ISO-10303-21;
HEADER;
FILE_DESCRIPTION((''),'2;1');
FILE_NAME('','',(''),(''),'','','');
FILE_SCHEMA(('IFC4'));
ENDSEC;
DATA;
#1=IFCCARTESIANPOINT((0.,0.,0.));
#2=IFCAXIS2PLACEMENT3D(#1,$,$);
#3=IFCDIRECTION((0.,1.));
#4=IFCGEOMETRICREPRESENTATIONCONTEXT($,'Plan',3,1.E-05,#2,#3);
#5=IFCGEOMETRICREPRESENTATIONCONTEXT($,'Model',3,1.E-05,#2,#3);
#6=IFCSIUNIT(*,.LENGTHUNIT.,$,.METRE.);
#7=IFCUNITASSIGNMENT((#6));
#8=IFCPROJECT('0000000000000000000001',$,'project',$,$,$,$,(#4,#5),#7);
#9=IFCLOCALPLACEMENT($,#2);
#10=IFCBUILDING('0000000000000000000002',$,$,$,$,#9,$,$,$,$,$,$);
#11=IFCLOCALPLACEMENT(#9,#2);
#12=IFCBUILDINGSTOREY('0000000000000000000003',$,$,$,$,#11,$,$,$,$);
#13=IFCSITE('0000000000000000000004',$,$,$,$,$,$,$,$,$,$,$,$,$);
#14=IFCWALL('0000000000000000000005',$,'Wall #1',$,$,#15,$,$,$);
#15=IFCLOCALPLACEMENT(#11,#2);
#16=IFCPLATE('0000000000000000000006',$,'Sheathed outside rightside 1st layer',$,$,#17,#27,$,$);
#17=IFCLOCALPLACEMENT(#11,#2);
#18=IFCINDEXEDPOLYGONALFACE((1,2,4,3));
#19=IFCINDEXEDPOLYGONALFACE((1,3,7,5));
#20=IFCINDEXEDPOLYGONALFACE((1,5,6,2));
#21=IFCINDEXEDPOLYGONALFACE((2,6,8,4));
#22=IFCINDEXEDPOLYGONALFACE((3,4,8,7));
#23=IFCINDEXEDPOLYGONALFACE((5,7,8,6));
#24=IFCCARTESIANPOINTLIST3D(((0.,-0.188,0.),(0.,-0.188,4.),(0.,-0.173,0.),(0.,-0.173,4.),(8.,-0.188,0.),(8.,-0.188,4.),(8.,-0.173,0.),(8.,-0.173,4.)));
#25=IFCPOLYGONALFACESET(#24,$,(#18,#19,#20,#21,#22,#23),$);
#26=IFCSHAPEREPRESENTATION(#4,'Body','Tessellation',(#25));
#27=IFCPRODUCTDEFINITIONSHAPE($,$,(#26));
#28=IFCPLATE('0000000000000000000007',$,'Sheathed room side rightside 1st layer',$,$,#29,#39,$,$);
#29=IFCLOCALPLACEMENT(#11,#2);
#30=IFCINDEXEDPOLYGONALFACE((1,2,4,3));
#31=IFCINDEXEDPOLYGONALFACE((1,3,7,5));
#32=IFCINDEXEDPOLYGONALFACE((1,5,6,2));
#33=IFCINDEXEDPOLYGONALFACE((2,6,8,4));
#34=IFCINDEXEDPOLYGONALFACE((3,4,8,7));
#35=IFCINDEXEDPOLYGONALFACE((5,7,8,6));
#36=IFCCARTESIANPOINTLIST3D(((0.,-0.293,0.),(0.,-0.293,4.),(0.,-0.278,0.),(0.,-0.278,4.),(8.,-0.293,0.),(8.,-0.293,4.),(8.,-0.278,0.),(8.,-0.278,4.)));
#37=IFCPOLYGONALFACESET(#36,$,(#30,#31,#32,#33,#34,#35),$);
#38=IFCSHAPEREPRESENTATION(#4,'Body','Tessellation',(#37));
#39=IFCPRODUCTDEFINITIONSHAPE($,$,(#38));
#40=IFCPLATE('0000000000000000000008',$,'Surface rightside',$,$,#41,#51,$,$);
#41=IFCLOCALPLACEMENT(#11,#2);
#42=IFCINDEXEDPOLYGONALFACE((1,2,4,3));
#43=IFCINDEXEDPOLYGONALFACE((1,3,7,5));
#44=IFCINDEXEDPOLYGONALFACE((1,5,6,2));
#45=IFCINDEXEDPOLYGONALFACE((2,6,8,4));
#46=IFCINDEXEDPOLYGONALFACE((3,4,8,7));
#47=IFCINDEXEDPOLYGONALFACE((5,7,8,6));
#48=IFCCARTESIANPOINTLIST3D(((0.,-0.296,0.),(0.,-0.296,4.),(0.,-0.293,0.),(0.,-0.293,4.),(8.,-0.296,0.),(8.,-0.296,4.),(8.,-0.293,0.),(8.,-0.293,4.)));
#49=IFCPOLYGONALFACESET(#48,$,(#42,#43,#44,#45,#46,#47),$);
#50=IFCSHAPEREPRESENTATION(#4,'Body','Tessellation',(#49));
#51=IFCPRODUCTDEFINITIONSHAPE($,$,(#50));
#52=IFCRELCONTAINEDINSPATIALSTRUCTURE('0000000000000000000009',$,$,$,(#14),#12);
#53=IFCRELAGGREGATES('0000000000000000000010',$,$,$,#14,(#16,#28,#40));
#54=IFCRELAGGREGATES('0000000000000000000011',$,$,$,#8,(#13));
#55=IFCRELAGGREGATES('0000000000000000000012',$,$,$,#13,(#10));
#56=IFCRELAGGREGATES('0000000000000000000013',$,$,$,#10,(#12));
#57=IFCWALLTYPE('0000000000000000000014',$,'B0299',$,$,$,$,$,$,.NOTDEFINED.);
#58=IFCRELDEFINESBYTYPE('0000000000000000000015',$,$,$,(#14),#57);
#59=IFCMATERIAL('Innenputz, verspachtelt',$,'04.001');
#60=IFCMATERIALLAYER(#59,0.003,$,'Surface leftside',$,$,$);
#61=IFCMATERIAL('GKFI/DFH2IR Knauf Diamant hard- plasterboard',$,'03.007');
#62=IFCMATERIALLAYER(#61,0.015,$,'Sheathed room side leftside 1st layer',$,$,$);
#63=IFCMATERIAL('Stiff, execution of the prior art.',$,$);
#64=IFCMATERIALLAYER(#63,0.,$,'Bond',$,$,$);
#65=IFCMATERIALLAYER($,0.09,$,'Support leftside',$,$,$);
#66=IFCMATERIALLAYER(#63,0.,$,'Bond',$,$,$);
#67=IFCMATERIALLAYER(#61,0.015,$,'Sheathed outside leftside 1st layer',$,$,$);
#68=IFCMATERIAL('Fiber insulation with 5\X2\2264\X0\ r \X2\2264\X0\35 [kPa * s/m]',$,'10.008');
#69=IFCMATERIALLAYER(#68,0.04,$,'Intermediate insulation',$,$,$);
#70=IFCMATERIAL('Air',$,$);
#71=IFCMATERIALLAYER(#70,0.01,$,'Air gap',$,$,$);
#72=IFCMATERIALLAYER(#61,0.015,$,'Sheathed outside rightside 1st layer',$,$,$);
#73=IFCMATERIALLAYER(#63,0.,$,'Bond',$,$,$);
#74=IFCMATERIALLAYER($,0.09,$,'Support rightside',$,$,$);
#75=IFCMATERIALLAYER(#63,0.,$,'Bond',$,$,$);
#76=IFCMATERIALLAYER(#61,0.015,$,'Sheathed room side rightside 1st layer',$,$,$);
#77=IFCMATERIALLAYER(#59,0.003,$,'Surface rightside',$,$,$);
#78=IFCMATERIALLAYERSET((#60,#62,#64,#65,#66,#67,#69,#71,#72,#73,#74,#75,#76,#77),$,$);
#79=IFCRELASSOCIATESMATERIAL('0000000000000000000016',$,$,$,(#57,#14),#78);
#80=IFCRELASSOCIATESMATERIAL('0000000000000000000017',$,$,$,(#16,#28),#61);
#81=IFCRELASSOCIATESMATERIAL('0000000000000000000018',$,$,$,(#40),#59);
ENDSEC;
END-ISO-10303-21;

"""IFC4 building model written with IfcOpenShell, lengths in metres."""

from ifc_helpers import new_model, si_unit, direction, frame, frame_2d, origin, place, context, project, spatial, rectangle, extrude, material, layer, layer_set, type_object, element, aggregate, save


model = new_model("IFC4")

# Units and contexts
plan_context = context("Plan", 3, precision=1e-05, world=origin(), true_north=direction((0.0, 1.0)))
model_context = context("Model", 3, precision=1e-05, world=origin(), true_north=direction((0.0, 1.0)))
ifc_project = project(units=[si_unit("LENGTHUNIT", "METRE")], contexts=[plan_context, model_context])

# Site, building, storey
site = spatial("IfcSite", under=ifc_project)
building_placement = place(None, origin())
building = spatial("IfcBuilding", under=site, at=building_placement)
storey_placement = place(building_placement, origin())
storey = spatial("IfcBuildingStorey", under=building, at=storey_placement)

# Wall, plates
ifc_material_1 = material(Name="Innenputz, verspachtelt", Category="04.001")
ifc_layer_1 = layer(ifc_material_1, 0.003, Name="Surface leftside")
ifc_material_2 = material(Name="GKFI/DFH2IR Knauf Diamant hard- plasterboard", Category="03.007")
ifc_layer_2 = layer(ifc_material_2, 0.015, Name="Sheathed room side leftside 1st layer")
ifc_material_3 = material(Name="Stiff, execution of the prior art.")
ifc_layer_3 = layer(ifc_material_3, 0.0, Name="Bond")
ifc_layer_4 = layer(None, 0.09, Name="Support leftside")
ifc_layer_5 = layer(ifc_material_3, 0.0, Name="Bond")
ifc_layer_6 = layer(ifc_material_2, 0.015, Name="Sheathed outside leftside 1st layer")
ifc_material_4 = material(Name="Fiber insulation with 5≤ r ≤35 [kPa * s/m]", Category="10.008")
ifc_layer_7 = layer(ifc_material_4, 0.04, Name="Intermediate insulation")
ifc_material_5 = material(Name="Air")
ifc_layer_8 = layer(ifc_material_5, 0.01, Name="Air gap")
ifc_layer_9 = layer(ifc_material_2, 0.015, Name="Sheathed outside rightside 1st layer")
ifc_layer_10 = layer(ifc_material_3, 0.0, Name="Bond")
ifc_layer_11 = layer(None, 0.09, Name="Support rightside")
ifc_layer_12 = layer(ifc_material_3, 0.0, Name="Bond")
ifc_layer_13 = layer(ifc_material_2, 0.015, Name="Sheathed room side rightside 1st layer")
ifc_layer_14 = layer(ifc_material_1, 0.003, Name="Surface rightside")
ifc_layer_set = layer_set([ifc_layer_1, ifc_layer_2, ifc_layer_3, ifc_layer_4, ifc_layer_5, ifc_layer_6, ifc_layer_7, ifc_layer_8, ifc_layer_9, ifc_layer_10, ifc_layer_11, ifc_layer_12, ifc_layer_13, ifc_layer_14])
wall_type = type_object("IfcWallType", Name="B0299", PredefinedType="NOTDEFINED", material=ifc_layer_set)
wall_placement = place(None, frame((0.0, 0.0, 0.0), z_axis=(0.0, -1.0, 0.0), x_axis=(1.0, 0.0, 0.0)))
wall = element("IfcWall", 1, at=wall_placement, inside=storey, type_object=wall_type, material=ifc_layer_set, Name="Wall #1")
plate_1_placement = place(wall_placement, origin())
plate_1 = element("IfcPlate", 2, at=plate_1_placement, material=ifc_material_2, Name="Sheathed outside rightside 1st layer", context=plan_context, shape_type="SweptSolid", body=[
    extrude(rectangle(XDim=8.0, YDim=4.0, at=frame_2d((4.0, 2.0), x_axis=(1.0, 0.0))), frame((0.0, 0.0, 0.173), z_axis=(0.0, 0.0, 1.0), x_axis=(1.0, 0.0, 0.0)), (0.0, 0.0, 1.0), 0.015),
])
plate_2_placement = place(wall_placement, origin())
plate_2 = element("IfcPlate", 3, at=plate_2_placement, material=ifc_material_2, Name="Sheathed room side rightside 1st layer", context=plan_context, shape_type="SweptSolid", body=[
    extrude(rectangle(XDim=8.0, YDim=4.0, at=frame_2d((4.0, 2.0), x_axis=(1.0, 0.0))), frame((0.0, 0.0, 0.278), z_axis=(0.0, 0.0, 1.0), x_axis=(1.0, 0.0, 0.0)), (0.0, 0.0, 1.0), 0.015),
])
plate_3_placement = place(wall_placement, origin())
plate_3 = element("IfcPlate", 4, at=plate_3_placement, material=ifc_material_1, Name="Surface rightside", context=plan_context, shape_type="SweptSolid", body=[
    extrude(rectangle(XDim=8.0, YDim=4.0, at=frame_2d((4.0, 2.0), x_axis=(1.0, 0.0))), frame((0.0, 0.0, 0.293), z_axis=(0.0, 0.0, 1.0), x_axis=(1.0, 0.0, 0.0)), (0.0, 0.0, 1.0), 0.003),
])
aggregate(wall, [plate_1, plate_2, plate_3])

save(model, "model.ifc")
